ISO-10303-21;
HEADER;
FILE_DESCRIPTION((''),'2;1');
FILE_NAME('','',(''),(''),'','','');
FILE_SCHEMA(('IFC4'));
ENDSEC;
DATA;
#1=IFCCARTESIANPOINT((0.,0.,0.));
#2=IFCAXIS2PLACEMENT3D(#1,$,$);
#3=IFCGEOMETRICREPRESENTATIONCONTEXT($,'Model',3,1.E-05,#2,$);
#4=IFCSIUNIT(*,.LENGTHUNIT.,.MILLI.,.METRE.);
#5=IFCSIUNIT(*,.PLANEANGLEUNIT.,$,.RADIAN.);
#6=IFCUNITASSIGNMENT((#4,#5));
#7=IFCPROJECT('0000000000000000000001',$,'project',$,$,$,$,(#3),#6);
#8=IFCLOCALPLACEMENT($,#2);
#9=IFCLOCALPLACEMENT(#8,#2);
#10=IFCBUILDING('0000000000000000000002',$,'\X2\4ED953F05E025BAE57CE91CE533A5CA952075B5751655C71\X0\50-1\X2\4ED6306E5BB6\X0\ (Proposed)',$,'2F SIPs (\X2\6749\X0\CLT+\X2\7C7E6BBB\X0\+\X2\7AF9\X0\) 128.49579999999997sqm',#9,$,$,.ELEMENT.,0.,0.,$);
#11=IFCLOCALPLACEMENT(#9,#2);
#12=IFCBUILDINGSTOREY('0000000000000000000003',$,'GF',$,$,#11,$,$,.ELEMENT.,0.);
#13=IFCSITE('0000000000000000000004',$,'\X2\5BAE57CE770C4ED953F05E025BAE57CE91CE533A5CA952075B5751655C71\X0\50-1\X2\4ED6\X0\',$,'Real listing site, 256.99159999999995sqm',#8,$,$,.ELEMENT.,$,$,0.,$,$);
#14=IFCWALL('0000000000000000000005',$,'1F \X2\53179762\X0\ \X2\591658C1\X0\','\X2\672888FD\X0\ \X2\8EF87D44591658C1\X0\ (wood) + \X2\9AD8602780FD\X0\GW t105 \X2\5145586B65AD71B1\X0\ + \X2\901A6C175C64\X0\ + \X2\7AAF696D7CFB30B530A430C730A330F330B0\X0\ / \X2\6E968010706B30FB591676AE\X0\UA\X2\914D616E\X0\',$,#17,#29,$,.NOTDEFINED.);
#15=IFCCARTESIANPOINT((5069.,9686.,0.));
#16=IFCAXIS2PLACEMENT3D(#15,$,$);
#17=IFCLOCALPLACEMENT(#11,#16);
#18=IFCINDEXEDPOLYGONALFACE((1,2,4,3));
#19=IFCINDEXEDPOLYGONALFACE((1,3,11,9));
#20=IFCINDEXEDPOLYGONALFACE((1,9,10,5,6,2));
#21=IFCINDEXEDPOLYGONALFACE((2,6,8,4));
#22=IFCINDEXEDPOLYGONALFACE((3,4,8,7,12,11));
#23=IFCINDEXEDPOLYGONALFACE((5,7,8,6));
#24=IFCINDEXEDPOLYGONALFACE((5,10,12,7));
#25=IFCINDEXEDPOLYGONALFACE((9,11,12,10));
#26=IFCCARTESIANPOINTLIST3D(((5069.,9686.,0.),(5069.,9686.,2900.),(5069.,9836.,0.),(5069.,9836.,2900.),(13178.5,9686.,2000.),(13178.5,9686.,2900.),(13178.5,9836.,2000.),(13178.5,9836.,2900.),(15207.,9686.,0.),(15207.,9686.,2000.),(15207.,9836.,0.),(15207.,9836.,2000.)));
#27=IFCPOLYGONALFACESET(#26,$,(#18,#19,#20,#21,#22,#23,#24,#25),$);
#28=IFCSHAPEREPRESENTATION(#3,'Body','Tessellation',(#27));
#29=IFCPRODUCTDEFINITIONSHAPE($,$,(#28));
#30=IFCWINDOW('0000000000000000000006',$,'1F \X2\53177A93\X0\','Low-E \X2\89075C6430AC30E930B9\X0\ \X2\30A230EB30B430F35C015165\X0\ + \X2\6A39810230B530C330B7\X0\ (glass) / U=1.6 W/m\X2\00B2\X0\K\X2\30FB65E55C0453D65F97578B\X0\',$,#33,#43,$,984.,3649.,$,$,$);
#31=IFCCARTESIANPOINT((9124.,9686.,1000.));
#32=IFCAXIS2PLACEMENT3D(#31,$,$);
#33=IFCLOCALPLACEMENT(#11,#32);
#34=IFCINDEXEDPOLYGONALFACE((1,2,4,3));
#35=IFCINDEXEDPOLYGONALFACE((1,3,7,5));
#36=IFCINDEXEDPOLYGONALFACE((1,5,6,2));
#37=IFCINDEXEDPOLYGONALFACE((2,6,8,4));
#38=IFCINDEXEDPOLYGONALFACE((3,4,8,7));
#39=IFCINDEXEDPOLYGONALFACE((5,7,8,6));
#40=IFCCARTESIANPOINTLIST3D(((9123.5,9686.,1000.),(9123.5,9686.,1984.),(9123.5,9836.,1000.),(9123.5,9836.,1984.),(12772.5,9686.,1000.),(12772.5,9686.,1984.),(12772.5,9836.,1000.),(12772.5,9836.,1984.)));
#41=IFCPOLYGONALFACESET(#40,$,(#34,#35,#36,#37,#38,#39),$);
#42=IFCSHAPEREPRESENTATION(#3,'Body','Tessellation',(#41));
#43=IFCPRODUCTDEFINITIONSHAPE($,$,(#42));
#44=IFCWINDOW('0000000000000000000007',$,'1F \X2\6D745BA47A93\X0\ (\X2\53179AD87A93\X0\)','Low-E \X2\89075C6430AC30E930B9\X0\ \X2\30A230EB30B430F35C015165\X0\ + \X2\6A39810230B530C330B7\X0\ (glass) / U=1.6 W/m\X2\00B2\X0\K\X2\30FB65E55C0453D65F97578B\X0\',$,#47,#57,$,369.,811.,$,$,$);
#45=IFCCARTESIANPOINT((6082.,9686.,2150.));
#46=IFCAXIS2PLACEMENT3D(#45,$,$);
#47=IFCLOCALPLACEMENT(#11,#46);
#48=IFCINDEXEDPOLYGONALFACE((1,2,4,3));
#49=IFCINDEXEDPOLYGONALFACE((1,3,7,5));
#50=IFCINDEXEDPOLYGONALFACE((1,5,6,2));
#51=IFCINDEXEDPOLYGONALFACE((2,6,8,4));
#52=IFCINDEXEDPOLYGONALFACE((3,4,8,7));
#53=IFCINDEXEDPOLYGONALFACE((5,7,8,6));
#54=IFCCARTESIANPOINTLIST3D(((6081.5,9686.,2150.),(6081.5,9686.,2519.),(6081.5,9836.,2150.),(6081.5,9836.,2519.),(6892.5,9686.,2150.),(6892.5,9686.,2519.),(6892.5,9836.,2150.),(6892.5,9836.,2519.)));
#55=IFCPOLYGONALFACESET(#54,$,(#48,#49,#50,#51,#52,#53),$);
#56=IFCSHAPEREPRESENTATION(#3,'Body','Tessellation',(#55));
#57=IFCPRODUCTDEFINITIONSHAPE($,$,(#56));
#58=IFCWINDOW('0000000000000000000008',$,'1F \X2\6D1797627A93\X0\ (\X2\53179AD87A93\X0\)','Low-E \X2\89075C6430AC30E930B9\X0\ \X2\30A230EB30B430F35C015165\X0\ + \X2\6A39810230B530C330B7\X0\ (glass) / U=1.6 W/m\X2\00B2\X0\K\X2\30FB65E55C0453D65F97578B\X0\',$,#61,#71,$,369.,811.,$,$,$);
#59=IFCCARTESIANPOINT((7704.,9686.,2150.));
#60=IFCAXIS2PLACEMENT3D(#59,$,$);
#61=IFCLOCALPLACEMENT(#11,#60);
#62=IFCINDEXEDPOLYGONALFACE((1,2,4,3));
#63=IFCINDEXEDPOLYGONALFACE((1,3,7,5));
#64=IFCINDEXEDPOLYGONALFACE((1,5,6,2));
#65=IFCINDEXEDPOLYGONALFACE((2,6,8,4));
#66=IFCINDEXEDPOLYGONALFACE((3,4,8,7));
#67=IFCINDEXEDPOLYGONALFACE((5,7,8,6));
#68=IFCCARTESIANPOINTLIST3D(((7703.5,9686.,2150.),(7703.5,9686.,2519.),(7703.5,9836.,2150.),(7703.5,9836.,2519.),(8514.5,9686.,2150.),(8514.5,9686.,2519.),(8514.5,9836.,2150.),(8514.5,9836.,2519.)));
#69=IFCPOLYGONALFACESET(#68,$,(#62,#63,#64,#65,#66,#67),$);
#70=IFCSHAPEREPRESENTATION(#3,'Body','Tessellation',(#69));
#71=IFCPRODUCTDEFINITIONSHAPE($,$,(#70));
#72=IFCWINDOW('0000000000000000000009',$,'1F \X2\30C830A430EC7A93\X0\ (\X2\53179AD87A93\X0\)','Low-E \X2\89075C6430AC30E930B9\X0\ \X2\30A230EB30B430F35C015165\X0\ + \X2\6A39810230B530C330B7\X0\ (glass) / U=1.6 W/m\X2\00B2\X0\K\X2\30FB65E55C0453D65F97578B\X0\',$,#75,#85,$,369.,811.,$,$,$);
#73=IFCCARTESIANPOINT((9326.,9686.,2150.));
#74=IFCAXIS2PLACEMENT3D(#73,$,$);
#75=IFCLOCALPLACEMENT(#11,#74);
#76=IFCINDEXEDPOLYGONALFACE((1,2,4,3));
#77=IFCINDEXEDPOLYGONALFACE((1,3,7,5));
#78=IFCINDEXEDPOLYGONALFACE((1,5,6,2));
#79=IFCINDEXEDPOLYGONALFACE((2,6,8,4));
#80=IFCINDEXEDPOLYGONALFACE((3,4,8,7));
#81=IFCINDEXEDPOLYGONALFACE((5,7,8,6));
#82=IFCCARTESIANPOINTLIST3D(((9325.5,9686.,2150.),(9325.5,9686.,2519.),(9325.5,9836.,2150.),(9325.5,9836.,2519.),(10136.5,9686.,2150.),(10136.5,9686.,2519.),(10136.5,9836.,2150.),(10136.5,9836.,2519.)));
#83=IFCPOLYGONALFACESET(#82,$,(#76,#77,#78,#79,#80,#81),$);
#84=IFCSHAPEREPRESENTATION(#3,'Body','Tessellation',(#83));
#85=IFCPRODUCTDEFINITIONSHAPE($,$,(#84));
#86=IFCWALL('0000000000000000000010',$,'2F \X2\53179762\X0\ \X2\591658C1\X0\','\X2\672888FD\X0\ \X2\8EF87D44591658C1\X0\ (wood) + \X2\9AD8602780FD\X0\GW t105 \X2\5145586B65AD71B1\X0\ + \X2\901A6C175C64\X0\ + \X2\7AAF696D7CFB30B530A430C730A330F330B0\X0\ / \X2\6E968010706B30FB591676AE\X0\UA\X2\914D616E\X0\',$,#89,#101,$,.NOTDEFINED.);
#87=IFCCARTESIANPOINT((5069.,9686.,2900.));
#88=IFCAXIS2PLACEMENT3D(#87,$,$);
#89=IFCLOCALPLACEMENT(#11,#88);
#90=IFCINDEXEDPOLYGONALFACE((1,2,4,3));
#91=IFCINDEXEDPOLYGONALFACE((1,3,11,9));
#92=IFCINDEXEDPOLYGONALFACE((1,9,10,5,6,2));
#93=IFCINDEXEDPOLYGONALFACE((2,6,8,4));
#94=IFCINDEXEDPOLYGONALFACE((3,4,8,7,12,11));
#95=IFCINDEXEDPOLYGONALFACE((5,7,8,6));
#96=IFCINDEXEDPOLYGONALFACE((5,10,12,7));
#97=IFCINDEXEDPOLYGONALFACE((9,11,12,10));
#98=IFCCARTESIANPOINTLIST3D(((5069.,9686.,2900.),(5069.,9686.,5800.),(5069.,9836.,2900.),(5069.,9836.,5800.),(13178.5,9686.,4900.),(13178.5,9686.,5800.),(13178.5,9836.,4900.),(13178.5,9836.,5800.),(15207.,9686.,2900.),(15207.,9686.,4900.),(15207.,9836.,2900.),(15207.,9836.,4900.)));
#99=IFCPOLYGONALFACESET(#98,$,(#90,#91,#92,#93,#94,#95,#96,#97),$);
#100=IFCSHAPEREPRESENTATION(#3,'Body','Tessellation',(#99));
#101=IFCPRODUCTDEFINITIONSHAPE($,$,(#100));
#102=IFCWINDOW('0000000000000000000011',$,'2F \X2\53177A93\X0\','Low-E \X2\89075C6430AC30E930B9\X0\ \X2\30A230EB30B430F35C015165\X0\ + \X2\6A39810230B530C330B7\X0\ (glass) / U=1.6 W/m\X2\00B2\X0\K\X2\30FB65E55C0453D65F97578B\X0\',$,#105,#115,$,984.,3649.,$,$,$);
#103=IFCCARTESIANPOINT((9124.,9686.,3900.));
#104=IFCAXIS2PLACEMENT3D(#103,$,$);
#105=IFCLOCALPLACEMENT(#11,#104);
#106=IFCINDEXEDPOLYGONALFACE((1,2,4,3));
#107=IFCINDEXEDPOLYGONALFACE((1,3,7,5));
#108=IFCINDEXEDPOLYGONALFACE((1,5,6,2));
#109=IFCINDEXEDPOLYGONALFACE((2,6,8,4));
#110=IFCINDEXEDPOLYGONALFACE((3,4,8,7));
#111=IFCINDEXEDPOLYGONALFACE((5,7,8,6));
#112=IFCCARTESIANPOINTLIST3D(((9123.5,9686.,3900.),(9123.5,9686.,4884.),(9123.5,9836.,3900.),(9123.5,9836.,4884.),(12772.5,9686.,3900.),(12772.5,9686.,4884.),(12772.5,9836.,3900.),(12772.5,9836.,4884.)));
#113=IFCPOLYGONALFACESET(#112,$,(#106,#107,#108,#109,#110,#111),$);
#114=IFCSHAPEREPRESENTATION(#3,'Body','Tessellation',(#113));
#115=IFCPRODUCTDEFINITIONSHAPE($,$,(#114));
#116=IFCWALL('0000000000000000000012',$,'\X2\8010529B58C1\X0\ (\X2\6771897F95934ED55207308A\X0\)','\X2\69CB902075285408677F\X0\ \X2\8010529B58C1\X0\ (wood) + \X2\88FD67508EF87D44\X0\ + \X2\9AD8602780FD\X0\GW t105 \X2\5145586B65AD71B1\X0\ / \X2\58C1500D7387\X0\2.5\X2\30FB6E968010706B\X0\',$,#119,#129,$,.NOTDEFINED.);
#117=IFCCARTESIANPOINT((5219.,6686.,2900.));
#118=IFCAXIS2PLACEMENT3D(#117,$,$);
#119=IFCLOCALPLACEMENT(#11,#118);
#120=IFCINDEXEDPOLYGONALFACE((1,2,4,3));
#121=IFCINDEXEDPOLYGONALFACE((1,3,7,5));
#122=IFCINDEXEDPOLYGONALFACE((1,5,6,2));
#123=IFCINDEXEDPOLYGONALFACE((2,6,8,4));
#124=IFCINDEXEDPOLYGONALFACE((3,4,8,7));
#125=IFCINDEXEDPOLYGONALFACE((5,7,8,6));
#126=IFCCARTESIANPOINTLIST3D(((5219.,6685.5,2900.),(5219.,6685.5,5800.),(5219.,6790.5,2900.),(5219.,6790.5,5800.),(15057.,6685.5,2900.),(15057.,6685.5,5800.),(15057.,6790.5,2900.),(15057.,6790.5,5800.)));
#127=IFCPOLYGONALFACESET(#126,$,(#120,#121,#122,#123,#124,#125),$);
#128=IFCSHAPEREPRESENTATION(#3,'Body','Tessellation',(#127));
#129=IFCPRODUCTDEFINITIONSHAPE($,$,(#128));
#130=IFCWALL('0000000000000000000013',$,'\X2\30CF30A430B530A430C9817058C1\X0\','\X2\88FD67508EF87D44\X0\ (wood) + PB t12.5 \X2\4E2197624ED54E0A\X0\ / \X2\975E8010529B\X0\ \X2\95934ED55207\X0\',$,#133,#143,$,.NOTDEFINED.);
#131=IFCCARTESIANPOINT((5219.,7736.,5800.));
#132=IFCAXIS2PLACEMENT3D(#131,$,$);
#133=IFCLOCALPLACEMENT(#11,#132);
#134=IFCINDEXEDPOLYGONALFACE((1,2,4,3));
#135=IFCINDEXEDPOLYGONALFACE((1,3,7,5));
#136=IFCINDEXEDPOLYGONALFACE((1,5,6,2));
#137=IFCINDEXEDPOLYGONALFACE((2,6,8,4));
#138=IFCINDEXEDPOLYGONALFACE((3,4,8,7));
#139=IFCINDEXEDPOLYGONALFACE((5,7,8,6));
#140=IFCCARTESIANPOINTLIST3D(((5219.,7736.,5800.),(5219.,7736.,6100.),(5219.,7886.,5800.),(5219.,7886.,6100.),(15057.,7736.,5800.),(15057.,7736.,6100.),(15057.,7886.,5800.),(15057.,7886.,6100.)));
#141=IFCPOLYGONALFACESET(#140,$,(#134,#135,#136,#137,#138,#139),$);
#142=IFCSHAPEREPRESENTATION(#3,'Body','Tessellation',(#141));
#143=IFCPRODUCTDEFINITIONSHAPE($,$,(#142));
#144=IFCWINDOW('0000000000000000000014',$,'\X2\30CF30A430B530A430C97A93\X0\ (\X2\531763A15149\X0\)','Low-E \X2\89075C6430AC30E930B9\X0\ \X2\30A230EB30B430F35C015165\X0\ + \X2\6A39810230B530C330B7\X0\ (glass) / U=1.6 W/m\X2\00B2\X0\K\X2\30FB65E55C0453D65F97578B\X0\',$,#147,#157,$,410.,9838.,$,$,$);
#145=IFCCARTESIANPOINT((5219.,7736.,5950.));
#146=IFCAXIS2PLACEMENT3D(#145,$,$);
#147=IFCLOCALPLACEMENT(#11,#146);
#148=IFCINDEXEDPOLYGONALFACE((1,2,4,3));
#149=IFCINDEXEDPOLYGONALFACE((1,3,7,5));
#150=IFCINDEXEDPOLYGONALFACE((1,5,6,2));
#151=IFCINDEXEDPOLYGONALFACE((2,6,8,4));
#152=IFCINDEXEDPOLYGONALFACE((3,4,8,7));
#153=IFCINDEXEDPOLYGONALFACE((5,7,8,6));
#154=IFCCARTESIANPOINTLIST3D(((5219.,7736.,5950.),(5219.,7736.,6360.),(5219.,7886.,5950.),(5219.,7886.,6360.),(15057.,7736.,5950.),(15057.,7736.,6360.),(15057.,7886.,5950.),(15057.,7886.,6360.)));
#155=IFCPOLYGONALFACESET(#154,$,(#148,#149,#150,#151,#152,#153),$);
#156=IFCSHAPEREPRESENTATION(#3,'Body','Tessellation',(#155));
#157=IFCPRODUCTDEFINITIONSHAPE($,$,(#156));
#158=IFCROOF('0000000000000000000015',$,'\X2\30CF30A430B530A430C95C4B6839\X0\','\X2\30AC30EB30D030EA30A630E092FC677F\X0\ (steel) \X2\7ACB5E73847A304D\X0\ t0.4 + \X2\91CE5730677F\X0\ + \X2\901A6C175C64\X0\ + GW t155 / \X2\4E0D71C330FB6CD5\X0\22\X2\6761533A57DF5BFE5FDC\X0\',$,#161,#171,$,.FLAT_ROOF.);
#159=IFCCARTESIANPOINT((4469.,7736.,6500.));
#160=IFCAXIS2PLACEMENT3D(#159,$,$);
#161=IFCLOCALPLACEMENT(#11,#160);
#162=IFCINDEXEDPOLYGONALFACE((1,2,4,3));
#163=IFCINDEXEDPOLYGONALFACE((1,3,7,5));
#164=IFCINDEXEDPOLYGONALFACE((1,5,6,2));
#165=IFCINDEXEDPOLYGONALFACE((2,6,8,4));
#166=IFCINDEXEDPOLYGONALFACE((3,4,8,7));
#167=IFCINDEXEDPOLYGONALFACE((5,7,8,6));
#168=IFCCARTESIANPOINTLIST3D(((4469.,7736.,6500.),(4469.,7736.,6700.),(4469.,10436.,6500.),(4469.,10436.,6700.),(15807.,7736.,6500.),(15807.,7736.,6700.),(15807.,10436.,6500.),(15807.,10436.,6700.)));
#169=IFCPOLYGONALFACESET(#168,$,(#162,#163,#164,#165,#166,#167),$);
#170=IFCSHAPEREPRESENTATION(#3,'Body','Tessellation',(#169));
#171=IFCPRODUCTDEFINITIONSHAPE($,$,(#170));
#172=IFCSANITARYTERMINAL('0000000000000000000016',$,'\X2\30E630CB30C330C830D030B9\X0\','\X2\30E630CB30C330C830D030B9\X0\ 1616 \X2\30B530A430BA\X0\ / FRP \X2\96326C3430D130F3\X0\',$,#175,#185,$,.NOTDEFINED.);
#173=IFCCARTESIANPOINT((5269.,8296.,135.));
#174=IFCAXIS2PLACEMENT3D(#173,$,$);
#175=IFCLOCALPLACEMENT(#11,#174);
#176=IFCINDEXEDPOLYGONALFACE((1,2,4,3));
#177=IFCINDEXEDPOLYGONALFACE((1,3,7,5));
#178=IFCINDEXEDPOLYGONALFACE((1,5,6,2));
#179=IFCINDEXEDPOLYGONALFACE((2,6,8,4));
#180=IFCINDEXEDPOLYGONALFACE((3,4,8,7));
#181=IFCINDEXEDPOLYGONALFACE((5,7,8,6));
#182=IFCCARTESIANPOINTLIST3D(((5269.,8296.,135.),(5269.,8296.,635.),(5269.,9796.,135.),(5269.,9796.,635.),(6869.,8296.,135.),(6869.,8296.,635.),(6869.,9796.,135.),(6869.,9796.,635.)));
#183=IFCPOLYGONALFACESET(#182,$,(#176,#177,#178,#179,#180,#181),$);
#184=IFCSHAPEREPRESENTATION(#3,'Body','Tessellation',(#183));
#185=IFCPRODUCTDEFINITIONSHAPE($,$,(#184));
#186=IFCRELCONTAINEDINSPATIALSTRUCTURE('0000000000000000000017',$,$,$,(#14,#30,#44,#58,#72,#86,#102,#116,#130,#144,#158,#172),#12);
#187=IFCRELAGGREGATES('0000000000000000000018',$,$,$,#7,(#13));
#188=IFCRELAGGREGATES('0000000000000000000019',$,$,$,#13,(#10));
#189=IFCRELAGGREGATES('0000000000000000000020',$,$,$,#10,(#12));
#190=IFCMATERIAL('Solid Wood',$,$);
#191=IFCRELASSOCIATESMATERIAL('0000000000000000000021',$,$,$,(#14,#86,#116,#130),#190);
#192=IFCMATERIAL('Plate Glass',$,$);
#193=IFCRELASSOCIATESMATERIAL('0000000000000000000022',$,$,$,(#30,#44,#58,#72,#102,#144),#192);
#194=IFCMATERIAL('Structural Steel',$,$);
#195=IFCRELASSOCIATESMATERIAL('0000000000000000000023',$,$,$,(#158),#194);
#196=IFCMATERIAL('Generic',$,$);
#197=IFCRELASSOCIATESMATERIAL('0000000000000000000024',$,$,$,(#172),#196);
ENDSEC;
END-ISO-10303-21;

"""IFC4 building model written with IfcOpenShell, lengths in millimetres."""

from ifc_helpers import new_model, si_unit, frame, frame_2d, origin, place, context, project, spatial, rectangle, extrude, material, element, fill, save


model = new_model("IFC4")

# Units and contexts
model_context = context("Model", 3, precision=1e-05, world=origin())
ifc_project = project(units=[si_unit("LENGTHUNIT", "METRE", prefix="MILLI"), si_unit("PLANEANGLEUNIT", "RADIAN")], contexts=[model_context])

# Site, building, storey
site_placement = place(None, origin())
site = spatial("IfcSite", under=ifc_project, at=site_placement, Name="宮城県仙台市宮城野区岩切字入山50-1他", ObjectType="Real listing site, 256.99159999999995sqm", CompositionType="ELEMENT", RefElevation=0.0)
building_placement = place(site_placement, origin())
building = spatial("IfcBuilding", under=site, at=building_placement, Name="仙台市宮城野区岩切字入山50-1他の家 (Proposed)", ObjectType="2F SIPs (杉CLT+籾殻+竹) 128.49579999999997sqm", CompositionType="ELEMENT", ElevationOfRefHeight=0.0, ElevationOfTerrain=0.0)
storey_placement = place(building_placement, origin())
storey = spatial("IfcBuildingStorey", under=building, at=storey_placement, Name="GF", CompositionType="ELEMENT", Elevation=0.0)

# Wall, openings, windows
ifc_material_1 = material(Name="Solid Wood")
wall_1_placement = place(storey_placement, frame((5069.0, 9686.0, 0.0)))
wall_1 = element("IfcWall", 1, at=wall_1_placement, inside=storey, material=ifc_material_1, Name="1F 北面 外壁", Description="木製 軸組外壁 (wood) + 高性能GW t105 充填断熱 + 通気層 + 窯業系サイディング / 準耐火・外皮UA配慮", PredefinedType="NOTDEFINED", context=model_context, shape_type="SweptSolid", body=[
    extrude(rectangle(XDim=10138.0, YDim=150.0, at=frame_2d((5069.0, 75.0))), frame((5069.0, 9686.0, 0.0)), (0.0, 0.0, 1.0), 2900.0),
])
opening_1_placement = place(storey_placement, frame((9124.0, 9686.0, 1000.0)))
opening_1 = element("IfcOpeningElement", 2, at=opening_1_placement, cuts=wall_1, PredefinedType="NOTDEFINED", context=model_context, shape_type="SweptSolid", body=[
    extrude(rectangle(XDim=3649.0, YDim=150.0, at=frame_2d((1824.0, 75.0))), frame((9124.0, 9686.0, 1000.0)), (0.0, 0.0, 1.0), 984.0),
])
opening_2_placement = place(storey_placement, frame((6082.0, 9686.0, 2150.0)))
opening_2 = element("IfcOpeningElement", 3, at=opening_2_placement, cuts=wall_1, PredefinedType="NOTDEFINED", context=model_context, shape_type="SweptSolid", body=[
    extrude(rectangle(XDim=811.0, YDim=150.0, at=frame_2d((405.0, 75.0))), frame((6082.0, 9686.0, 2150.0)), (0.0, 0.0, 1.0), 369.0),
])
opening_3_placement = place(storey_placement, frame((7704.0, 9686.0, 2150.0)))
opening_3 = element("IfcOpeningElement", 4, at=opening_3_placement, cuts=wall_1, PredefinedType="NOTDEFINED", context=model_context, shape_type="SweptSolid", body=[
    extrude(rectangle(XDim=811.0, YDim=150.0, at=frame_2d((405.0, 75.0))), frame((7704.0, 9686.0, 2150.0)), (0.0, 0.0, 1.0), 369.0),
])
opening_4_placement = place(storey_placement, frame((9326.0, 9686.0, 2150.0)))
opening_4 = element("IfcOpeningElement", 5, at=opening_4_placement, cuts=wall_1, PredefinedType="NOTDEFINED", context=model_context, shape_type="SweptSolid", body=[
    extrude(rectangle(XDim=811.0, YDim=150.0, at=frame_2d((405.0, 75.0))), frame((9326.0, 9686.0, 2150.0)), (0.0, 0.0, 1.0), 369.0),
])
ifc_material_2 = material(Name="Plate Glass")
window_1_placement = place(storey_placement, frame((9124.0, 9686.0, 1000.0)))
window_1 = element("IfcWindow", 6, at=window_1_placement, inside=storey, material=ifc_material_2, Name="1F 北窓", Description="Low-E 複層ガラス アルゴン封入 + 樹脂サッシ (glass) / U=1.6 W/m²K・日射取得型", OverallHeight=984.0, OverallWidth=3649.0, context=model_context, shape_type="SweptSolid", body=[
    extrude(rectangle(XDim=3649.0, YDim=150.0, at=frame_2d((1824.0, 75.0))), frame((9124.0, 9686.0, 1000.0)), (0.0, 0.0, 1.0), 984.0),
])
fill(opening_1, window_1)
window_2_placement = place(storey_placement, frame((6082.0, 9686.0, 2150.0)))
window_2 = element("IfcWindow", 7, at=window_2_placement, inside=storey, material=ifc_material_2, Name="1F 浴室窓 (北高窓)", Description="Low-E 複層ガラス アルゴン封入 + 樹脂サッシ (glass) / U=1.6 W/m²K・日射取得型", OverallHeight=369.0, OverallWidth=811.0, context=model_context, shape_type="SweptSolid", body=[
    extrude(rectangle(XDim=811.0, YDim=150.0, at=frame_2d((405.0, 75.0))), frame((6082.0, 9686.0, 2150.0)), (0.0, 0.0, 1.0), 369.0),
])
fill(opening_2, window_2)
window_3_placement = place(storey_placement, frame((7704.0, 9686.0, 2150.0)))
window_3 = element("IfcWindow", 8, at=window_3_placement, inside=storey, material=ifc_material_2, Name="1F 洗面窓 (北高窓)", Description="Low-E 複層ガラス アルゴン封入 + 樹脂サッシ (glass) / U=1.6 W/m²K・日射取得型", OverallHeight=369.0, OverallWidth=811.0, context=model_context, shape_type="SweptSolid", body=[
    extrude(rectangle(XDim=811.0, YDim=150.0, at=frame_2d((405.0, 75.0))), frame((7704.0, 9686.0, 2150.0)), (0.0, 0.0, 1.0), 369.0),
])
fill(opening_3, window_3)
window_4_placement = place(storey_placement, frame((9326.0, 9686.0, 2150.0)))
window_4 = element("IfcWindow", 9, at=window_4_placement, inside=storey, material=ifc_material_2, Name="1F トイレ窓 (北高窓)", Description="Low-E 複層ガラス アルゴン封入 + 樹脂サッシ (glass) / U=1.6 W/m²K・日射取得型", OverallHeight=369.0, OverallWidth=811.0, context=model_context, shape_type="SweptSolid", body=[
    extrude(rectangle(XDim=811.0, YDim=150.0, at=frame_2d((405.0, 75.0))), frame((9326.0, 9686.0, 2150.0)), (0.0, 0.0, 1.0), 369.0),
])
fill(opening_4, window_4)

# Wall, opening, window
wall_2_placement = place(storey_placement, frame((5069.0, 9686.0, 2900.0)))
wall_2 = element("IfcWall", 10, at=wall_2_placement, inside=storey, material=ifc_material_1, Name="2F 北面 外壁", Description="木製 軸組外壁 (wood) + 高性能GW t105 充填断熱 + 通気層 + 窯業系サイディング / 準耐火・外皮UA配慮", PredefinedType="NOTDEFINED", context=model_context, shape_type="SweptSolid", body=[
    extrude(rectangle(XDim=10138.0, YDim=150.0, at=frame_2d((5069.0, 75.0))), frame((5069.0, 9686.0, 2900.0)), (0.0, 0.0, 1.0), 2900.0),
])
opening_5_placement = place(storey_placement, frame((9124.0, 9686.0, 3900.0)))
opening_5 = element("IfcOpeningElement", 11, at=opening_5_placement, cuts=wall_2, PredefinedType="NOTDEFINED", context=model_context, shape_type="SweptSolid", body=[
    extrude(rectangle(XDim=3649.0, YDim=150.0, at=frame_2d((1824.0, 75.0))), frame((9124.0, 9686.0, 3900.0)), (0.0, 0.0, 1.0), 984.0),
])
window_5_placement = place(storey_placement, frame((9124.0, 9686.0, 3900.0)))
window_5 = element("IfcWindow", 12, at=window_5_placement, inside=storey, material=ifc_material_2, Name="2F 北窓", Description="Low-E 複層ガラス アルゴン封入 + 樹脂サッシ (glass) / U=1.6 W/m²K・日射取得型", OverallHeight=984.0, OverallWidth=3649.0, context=model_context, shape_type="SweptSolid", body=[
    extrude(rectangle(XDim=3649.0, YDim=150.0, at=frame_2d((1824.0, 75.0))), frame((9124.0, 9686.0, 3900.0)), (0.0, 0.0, 1.0), 984.0),
])
fill(opening_5, window_5)

# Wall
wall_3_placement = place(storey_placement, frame((5219.0, 6686.0, 2900.0)))
element("IfcWall", 13, at=wall_3_placement, inside=storey, material=ifc_material_1, Name="耐力壁 (東西間仕切り)", Description="構造用合板 耐力壁 (wood) + 製材軸組 + 高性能GW t105 充填断熱 / 壁倍率2.5・準耐火", PredefinedType="NOTDEFINED", context=model_context, shape_type="SweptSolid", body=[
    extrude(rectangle(XDim=9838.0, YDim=105.0, at=frame_2d((4919.0, 52.0))), frame((5219.0, 6686.0, 2900.0)), (0.0, 0.0, 1.0), 2900.0),
])

# Wall, opening, window
wall_4_placement = place(storey_placement, frame((5219.0, 7736.0, 5800.0)))
wall_4 = element("IfcWall", 14, at=wall_4_placement, inside=storey, material=ifc_material_1, Name="ハイサイド腰壁", Description="製材軸組 (wood) + PB t12.5 両面仕上 / 非耐力 間仕切", PredefinedType="NOTDEFINED", context=model_context, shape_type="SweptSolid", body=[
    extrude(rectangle(XDim=9838.0, YDim=150.0, at=frame_2d((4919.0, 75.0))), frame((5219.0, 7736.0, 5800.0)), (0.0, 0.0, 1.0), 700.0),
])
opening_6_placement = place(storey_placement, frame((5219.0, 7736.0, 5950.0)))
opening_6 = element("IfcOpeningElement", 15, at=opening_6_placement, cuts=wall_4, PredefinedType="NOTDEFINED", context=model_context, shape_type="SweptSolid", body=[
    extrude(rectangle(XDim=9838.0, YDim=150.0, at=frame_2d((4919.0, 75.0))), frame((5219.0, 7736.0, 5950.0)), (0.0, 0.0, 1.0), 410.0),
])
window_6_placement = place(storey_placement, frame((5219.0, 7736.0, 5950.0)))
window_6 = element("IfcWindow", 16, at=window_6_placement, inside=storey, material=ifc_material_2, Name="ハイサイド窓 (北採光)", Description="Low-E 複層ガラス アルゴン封入 + 樹脂サッシ (glass) / U=1.6 W/m²K・日射取得型", OverallHeight=410.0, OverallWidth=9838.0, context=model_context, shape_type="SweptSolid", body=[
    extrude(rectangle(XDim=9838.0, YDim=150.0, at=frame_2d((4919.0, 75.0))), frame((5219.0, 7736.0, 5950.0)), (0.0, 0.0, 1.0), 410.0),
])
fill(opening_6, window_6)

# Roof
ifc_material_3 = material(Name="Structural Steel")
roof_placement = place(storey_placement, frame((4469.0, 7736.0, 6500.0)))
element("IfcRoof", 17, at=roof_placement, inside=storey, material=ifc_material_3, Name="ハイサイド屋根", Description="ガルバリウム鋼板 (steel) 立平葺き t0.4 + 野地板 + 通気層 + GW t155 / 不燃・法22条区域対応", PredefinedType="FLAT_ROOF", context=model_context, shape_type="SweptSolid", body=[
    extrude(rectangle(XDim=11338.0, YDim=2700.0, at=frame_2d((5669.0, 1350.0))), frame((4469.0, 7736.0, 6500.0)), (0.0, 0.0, 1.0), 200.0),
])

# Sanitary terminal
ifc_material_4 = material(Name="Generic")
sanitary_terminal_placement = place(storey_placement, frame((5269.0, 8296.0, 135.0)))
element("IfcSanitaryTerminal", 18, at=sanitary_terminal_placement, inside=storey, material=ifc_material_4, Name="ユニットバス", Description="ユニットバス 1616 サイズ / FRP 防水パン", PredefinedType="NOTDEFINED", context=model_context, shape_type="SweptSolid", body=[
    extrude(rectangle(XDim=1600.0, YDim=1500.0, at=frame_2d((800.0, 750.0))), frame((5269.0, 8296.0, 135.0)), (0.0, 0.0, 1.0), 500.0),
])

save(model, "model.ifc")
